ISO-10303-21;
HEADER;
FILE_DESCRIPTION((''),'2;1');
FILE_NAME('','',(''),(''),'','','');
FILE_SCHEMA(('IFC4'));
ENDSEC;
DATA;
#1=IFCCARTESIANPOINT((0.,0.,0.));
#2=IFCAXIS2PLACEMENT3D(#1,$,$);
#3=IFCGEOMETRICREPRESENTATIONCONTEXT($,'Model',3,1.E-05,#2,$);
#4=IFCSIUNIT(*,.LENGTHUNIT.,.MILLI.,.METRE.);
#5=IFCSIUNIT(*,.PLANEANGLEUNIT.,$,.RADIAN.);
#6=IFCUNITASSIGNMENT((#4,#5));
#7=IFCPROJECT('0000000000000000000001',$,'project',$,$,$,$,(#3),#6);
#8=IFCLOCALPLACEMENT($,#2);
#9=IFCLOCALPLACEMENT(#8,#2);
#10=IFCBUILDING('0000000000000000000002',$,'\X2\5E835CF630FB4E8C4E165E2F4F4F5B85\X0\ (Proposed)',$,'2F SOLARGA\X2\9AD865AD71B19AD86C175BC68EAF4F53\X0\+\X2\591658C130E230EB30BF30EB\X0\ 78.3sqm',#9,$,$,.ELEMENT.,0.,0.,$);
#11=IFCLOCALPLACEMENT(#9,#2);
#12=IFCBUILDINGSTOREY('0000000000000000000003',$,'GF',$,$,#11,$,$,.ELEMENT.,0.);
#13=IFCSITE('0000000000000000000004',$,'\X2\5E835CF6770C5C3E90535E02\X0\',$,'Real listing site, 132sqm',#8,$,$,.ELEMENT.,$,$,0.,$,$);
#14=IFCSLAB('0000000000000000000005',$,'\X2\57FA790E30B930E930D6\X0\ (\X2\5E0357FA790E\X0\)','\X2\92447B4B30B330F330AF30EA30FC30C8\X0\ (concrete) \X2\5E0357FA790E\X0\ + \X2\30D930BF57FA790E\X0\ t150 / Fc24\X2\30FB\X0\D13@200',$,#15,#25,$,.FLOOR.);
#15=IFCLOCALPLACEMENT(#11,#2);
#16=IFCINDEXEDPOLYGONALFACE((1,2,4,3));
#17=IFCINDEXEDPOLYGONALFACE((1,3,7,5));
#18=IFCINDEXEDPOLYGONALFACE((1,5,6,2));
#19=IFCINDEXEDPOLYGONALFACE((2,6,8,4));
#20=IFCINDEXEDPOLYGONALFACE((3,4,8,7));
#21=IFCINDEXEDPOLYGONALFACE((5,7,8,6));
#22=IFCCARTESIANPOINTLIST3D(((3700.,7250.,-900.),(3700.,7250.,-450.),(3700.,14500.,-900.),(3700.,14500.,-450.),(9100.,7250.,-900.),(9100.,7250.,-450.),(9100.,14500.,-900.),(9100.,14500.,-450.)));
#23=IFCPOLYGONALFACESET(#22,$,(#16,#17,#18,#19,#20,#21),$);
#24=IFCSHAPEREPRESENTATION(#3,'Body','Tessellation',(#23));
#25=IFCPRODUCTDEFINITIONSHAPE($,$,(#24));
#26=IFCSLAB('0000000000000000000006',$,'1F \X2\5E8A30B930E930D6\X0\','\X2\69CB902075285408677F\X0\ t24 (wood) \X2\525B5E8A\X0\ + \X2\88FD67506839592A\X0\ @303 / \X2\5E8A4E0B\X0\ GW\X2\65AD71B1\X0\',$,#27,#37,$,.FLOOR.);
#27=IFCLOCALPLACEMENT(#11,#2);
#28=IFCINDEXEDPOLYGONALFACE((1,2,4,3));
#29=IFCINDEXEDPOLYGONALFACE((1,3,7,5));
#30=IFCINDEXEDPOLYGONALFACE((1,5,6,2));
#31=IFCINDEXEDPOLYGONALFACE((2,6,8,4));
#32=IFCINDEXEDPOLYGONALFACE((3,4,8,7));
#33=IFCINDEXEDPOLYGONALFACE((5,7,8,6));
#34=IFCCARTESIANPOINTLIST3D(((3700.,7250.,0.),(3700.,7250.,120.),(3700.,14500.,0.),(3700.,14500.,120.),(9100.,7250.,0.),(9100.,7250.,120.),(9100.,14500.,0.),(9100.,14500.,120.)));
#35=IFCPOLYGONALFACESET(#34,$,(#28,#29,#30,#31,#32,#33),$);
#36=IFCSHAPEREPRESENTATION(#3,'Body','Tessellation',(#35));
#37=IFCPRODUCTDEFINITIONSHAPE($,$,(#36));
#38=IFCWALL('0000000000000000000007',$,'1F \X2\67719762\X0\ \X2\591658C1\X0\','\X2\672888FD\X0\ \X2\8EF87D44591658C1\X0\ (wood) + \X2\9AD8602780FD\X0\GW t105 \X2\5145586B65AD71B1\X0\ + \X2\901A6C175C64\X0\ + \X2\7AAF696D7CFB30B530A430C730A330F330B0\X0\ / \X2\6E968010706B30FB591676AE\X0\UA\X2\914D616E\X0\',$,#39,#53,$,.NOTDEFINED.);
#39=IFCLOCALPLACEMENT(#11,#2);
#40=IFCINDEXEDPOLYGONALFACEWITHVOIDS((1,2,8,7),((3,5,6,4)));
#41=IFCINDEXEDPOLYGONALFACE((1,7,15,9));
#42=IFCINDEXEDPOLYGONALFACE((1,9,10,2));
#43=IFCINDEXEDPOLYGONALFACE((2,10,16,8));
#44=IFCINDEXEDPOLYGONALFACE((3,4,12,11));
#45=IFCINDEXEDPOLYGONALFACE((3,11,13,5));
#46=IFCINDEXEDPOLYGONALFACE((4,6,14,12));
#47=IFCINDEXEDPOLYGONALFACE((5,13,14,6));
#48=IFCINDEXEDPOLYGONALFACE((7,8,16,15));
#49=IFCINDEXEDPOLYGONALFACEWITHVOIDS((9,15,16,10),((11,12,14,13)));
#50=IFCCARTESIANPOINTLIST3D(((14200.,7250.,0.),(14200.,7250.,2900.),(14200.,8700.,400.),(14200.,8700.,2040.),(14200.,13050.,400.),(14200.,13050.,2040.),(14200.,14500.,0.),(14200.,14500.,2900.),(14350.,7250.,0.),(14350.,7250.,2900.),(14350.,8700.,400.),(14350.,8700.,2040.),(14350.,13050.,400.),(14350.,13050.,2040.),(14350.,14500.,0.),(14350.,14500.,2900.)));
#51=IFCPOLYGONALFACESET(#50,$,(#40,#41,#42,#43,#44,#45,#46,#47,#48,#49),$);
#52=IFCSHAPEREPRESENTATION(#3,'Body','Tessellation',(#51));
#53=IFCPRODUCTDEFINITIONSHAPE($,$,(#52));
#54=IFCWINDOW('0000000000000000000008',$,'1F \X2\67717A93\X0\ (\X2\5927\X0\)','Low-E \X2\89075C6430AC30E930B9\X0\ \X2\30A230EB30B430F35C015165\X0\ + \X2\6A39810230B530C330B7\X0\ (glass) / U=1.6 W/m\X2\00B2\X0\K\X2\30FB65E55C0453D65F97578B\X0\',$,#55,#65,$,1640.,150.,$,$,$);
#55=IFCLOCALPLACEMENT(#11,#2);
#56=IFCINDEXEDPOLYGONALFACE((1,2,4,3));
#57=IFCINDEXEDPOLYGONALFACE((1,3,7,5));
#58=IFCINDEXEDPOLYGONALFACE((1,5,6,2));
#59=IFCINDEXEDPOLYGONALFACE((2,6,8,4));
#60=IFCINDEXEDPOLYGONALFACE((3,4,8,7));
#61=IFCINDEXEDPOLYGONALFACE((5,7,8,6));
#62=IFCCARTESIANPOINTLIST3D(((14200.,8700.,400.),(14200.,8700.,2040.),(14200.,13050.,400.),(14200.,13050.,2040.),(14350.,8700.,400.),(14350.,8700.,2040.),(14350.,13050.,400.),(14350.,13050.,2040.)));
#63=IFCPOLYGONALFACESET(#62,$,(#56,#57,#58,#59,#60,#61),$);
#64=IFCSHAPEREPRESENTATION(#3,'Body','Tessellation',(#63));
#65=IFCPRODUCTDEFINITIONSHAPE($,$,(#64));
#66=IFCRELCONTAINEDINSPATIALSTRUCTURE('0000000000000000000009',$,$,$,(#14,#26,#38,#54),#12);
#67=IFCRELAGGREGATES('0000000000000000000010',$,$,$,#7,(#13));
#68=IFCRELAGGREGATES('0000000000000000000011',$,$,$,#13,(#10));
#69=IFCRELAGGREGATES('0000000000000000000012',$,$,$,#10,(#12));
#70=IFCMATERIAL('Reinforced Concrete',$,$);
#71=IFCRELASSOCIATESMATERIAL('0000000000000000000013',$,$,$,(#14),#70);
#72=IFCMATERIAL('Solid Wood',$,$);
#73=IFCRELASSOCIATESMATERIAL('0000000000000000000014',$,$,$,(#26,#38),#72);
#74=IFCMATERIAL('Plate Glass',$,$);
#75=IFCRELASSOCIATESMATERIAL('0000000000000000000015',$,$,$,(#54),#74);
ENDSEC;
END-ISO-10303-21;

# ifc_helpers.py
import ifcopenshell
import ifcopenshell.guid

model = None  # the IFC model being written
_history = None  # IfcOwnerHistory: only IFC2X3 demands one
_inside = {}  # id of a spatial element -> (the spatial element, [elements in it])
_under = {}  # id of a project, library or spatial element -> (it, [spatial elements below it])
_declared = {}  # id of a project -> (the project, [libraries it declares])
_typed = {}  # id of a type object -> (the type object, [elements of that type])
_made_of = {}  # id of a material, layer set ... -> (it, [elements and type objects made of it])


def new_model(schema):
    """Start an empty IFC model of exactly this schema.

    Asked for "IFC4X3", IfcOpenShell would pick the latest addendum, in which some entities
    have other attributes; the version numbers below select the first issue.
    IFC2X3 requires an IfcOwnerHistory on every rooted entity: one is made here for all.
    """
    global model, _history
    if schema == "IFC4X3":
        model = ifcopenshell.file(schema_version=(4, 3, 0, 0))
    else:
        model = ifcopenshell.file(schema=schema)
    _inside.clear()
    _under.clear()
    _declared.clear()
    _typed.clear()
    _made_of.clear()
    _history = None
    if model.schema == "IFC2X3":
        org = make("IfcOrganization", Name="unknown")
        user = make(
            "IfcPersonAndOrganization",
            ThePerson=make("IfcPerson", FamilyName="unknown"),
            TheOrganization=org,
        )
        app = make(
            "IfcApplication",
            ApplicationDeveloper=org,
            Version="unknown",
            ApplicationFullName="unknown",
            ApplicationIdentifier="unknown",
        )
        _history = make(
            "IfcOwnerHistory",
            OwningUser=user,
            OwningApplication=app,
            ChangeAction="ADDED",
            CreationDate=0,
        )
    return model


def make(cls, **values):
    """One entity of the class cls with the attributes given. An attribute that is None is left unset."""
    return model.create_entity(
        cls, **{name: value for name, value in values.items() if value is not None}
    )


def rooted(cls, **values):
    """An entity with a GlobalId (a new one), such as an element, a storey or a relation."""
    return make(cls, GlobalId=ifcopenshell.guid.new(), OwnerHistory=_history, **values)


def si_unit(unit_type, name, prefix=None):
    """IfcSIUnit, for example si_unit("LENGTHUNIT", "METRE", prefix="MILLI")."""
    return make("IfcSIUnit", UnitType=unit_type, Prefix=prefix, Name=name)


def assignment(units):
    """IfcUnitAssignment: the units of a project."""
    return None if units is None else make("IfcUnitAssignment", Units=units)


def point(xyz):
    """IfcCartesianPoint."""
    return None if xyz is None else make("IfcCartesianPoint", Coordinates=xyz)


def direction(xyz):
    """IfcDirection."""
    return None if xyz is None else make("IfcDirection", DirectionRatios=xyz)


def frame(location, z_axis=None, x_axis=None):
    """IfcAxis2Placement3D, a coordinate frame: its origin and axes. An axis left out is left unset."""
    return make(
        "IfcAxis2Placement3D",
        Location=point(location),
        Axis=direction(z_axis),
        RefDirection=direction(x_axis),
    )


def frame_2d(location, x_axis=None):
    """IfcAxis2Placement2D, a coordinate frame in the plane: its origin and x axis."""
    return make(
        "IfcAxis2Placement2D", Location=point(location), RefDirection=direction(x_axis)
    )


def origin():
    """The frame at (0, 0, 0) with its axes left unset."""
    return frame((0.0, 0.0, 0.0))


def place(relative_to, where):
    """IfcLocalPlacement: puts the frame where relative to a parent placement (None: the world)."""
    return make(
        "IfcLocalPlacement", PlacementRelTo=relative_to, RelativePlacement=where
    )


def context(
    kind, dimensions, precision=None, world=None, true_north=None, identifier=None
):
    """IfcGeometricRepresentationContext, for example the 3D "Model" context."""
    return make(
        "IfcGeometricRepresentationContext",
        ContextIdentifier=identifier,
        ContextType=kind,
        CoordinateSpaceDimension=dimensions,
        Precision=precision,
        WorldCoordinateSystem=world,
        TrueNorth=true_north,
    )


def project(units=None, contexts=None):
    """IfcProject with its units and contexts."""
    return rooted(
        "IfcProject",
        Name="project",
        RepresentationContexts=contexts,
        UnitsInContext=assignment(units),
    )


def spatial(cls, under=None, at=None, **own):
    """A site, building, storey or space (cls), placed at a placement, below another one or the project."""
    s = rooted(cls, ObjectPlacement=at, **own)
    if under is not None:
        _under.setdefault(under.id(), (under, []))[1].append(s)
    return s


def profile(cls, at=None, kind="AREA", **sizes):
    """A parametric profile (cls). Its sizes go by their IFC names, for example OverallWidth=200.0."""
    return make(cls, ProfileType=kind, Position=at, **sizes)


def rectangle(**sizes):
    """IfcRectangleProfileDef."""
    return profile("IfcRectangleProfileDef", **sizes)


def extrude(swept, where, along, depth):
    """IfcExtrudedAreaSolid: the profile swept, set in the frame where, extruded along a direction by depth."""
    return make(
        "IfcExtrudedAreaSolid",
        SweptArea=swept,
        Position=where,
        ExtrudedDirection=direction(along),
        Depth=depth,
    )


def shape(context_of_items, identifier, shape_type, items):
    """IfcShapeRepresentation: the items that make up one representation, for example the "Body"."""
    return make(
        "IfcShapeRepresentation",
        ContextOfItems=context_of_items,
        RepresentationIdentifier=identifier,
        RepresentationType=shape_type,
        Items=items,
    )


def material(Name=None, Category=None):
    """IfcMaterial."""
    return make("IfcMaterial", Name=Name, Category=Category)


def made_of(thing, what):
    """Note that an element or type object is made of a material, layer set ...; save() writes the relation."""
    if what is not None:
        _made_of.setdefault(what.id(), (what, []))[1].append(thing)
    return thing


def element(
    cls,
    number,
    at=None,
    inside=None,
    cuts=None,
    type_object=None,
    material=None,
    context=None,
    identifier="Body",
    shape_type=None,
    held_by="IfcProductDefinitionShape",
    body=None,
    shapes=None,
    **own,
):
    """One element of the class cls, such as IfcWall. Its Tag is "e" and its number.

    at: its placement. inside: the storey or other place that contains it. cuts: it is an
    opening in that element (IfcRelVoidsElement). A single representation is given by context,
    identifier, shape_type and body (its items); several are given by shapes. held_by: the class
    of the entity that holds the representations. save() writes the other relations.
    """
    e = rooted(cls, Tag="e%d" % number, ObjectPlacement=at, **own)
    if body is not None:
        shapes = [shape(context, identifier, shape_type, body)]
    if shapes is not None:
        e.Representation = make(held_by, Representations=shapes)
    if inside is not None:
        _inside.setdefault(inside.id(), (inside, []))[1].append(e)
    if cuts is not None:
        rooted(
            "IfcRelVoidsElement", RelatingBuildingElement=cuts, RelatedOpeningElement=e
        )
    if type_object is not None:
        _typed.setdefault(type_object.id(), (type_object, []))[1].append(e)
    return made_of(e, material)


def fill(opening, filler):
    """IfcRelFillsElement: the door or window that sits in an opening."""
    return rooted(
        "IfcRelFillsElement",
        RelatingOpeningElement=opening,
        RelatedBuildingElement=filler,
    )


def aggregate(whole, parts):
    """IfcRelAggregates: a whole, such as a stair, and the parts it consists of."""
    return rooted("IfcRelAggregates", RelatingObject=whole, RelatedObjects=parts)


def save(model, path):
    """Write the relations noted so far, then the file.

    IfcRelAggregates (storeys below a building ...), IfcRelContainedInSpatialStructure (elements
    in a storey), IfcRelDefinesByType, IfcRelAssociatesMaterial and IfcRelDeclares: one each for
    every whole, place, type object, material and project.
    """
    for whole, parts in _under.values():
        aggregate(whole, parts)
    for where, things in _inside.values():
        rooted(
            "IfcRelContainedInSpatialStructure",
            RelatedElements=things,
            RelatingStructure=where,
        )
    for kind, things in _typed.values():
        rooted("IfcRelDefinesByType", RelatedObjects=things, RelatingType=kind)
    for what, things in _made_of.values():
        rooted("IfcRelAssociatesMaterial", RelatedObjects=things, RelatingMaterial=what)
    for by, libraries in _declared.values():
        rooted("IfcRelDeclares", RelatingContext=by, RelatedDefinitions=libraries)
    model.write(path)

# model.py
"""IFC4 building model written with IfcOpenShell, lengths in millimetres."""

from ifc_helpers import new_model, si_unit, frame, frame_2d, origin, place, context, project, spatial, rectangle, extrude, material, element, fill, save


model = new_model("IFC4")

# Units and contexts
model_context = context("Model", 3, precision=1e-05, world=origin())
ifc_project = project(units=[si_unit("LENGTHUNIT", "METRE", prefix="MILLI"), si_unit("PLANEANGLEUNIT", "RADIAN")], contexts=[model_context])

# Site, building, storey
site_placement = place(None, origin())
site = spatial("IfcSite", under=ifc_project, at=site_placement, Name="広島県尾道市", ObjectType="Real listing site, 132sqm", CompositionType="ELEMENT", RefElevation=0.0)
building_placement = place(site_placement, origin())
building = spatial("IfcBuilding", under=site, at=building_placement, Name="広島・二世帯住宅 (Proposed)", ObjectType="2F SOLARGA高断熱高気密躯体+外壁モルタル 78.3sqm", CompositionType="ELEMENT", ElevationOfRefHeight=0.0, ElevationOfTerrain=0.0)
storey_placement = place(building_placement, origin())
storey = spatial("IfcBuildingStorey", under=building, at=storey_placement, Name="GF", CompositionType="ELEMENT", Elevation=0.0)

# Shared definitions
ifc_material_1 = material(Name="Solid Wood")

# Slabs
ifc_material_2 = material(Name="Reinforced Concrete")
slab_1_placement = place(storey_placement, frame((1850.0, 3625.0, -450.0)))
element("IfcSlab", 1, at=slab_1_placement, inside=storey, material=ifc_material_2, Name="基礎スラブ (布基礎)", Description="鉄筋コンクリート (concrete) 布基礎 + ベタ基礎 t150 / Fc24・D13@200", PredefinedType="FLOOR", context=model_context, shape_type="SweptSolid", body=[
    extrude(rectangle(XDim=5400.0, YDim=7250.0, at=frame_2d((2700.0, 3625.0))), frame((1850.0, 3625.0, -450.0)), (0.0, 0.0, 1.0), 450.0),
])
slab_2_placement = place(storey_placement, frame((1850.0, 3625.0, 0.0)))
element("IfcSlab", 2, at=slab_2_placement, inside=storey, material=ifc_material_1, Name="1F 床スラブ", Description="構造用合板 t24 (wood) 剛床 + 製材根太 @303 / 床下 GW断熱", PredefinedType="FLOOR", context=model_context, shape_type="SweptSolid", body=[
    extrude(rectangle(XDim=5400.0, YDim=7250.0, at=frame_2d((2700.0, 3625.0))), frame((1850.0, 3625.0, 0.0)), (0.0, 0.0, 1.0), 120.0),
])

# Shared definitions
ifc_material_3 = material(Name="Plate Glass")

# Wall, opening, window
wall_1_placement = place(storey_placement, frame((7100.0, 3625.0, 0.0)))
wall_1 = element("IfcWall", 3, at=wall_1_placement, inside=storey, material=ifc_material_1, Name="1F 東面 外壁", Description="木製 軸組外壁 (wood) + 高性能GW t105 充填断熱 + 通気層 + 窯業系サイディング / 準耐火・外皮UA配慮", PredefinedType="NOTDEFINED", context=model_context, shape_type="SweptSolid", body=[
    extrude(rectangle(XDim=150.0, YDim=7250.0, at=frame_2d((75.0, 3625.0))), frame((7100.0, 3625.0, 0.0)), (0.0, 0.0, 1.0), 2900.0),
])
opening_1_placement = place(storey_placement, frame((7100.0, 4350.0, 200.0)))
opening_1 = element("IfcOpeningElement", 4, at=opening_1_placement, cuts=wall_1, PredefinedType="NOTDEFINED", context=model_context, shape_type="SweptSolid", body=[
    extrude(rectangle(XDim=150.0, YDim=4350.0, at=frame_2d((75.0, 2175.0))), frame((7100.0, 4350.0, 200.0)), (0.0, 0.0, 1.0), 1640.0),
])
window_1_placement = place(storey_placement, frame((7100.0, 4350.0, 200.0)))
window_1 = element("IfcWindow", 5, at=window_1_placement, inside=storey, material=ifc_material_3, Name="1F 東窓 (大)", Description="Low-E 複層ガラス アルゴン封入 + 樹脂サッシ (glass) / U=1.6 W/m²K・日射取得型", OverallHeight=1640.0, OverallWidth=150.0, context=model_context, shape_type="SweptSolid", body=[
    extrude(rectangle(XDim=150.0, YDim=4350.0, at=frame_2d((75.0, 2175.0))), frame((7100.0, 4350.0, 200.0)), (0.0, 0.0, 1.0), 1640.0),
])
fill(opening_1, window_1)

save(model, "model.ifc")
